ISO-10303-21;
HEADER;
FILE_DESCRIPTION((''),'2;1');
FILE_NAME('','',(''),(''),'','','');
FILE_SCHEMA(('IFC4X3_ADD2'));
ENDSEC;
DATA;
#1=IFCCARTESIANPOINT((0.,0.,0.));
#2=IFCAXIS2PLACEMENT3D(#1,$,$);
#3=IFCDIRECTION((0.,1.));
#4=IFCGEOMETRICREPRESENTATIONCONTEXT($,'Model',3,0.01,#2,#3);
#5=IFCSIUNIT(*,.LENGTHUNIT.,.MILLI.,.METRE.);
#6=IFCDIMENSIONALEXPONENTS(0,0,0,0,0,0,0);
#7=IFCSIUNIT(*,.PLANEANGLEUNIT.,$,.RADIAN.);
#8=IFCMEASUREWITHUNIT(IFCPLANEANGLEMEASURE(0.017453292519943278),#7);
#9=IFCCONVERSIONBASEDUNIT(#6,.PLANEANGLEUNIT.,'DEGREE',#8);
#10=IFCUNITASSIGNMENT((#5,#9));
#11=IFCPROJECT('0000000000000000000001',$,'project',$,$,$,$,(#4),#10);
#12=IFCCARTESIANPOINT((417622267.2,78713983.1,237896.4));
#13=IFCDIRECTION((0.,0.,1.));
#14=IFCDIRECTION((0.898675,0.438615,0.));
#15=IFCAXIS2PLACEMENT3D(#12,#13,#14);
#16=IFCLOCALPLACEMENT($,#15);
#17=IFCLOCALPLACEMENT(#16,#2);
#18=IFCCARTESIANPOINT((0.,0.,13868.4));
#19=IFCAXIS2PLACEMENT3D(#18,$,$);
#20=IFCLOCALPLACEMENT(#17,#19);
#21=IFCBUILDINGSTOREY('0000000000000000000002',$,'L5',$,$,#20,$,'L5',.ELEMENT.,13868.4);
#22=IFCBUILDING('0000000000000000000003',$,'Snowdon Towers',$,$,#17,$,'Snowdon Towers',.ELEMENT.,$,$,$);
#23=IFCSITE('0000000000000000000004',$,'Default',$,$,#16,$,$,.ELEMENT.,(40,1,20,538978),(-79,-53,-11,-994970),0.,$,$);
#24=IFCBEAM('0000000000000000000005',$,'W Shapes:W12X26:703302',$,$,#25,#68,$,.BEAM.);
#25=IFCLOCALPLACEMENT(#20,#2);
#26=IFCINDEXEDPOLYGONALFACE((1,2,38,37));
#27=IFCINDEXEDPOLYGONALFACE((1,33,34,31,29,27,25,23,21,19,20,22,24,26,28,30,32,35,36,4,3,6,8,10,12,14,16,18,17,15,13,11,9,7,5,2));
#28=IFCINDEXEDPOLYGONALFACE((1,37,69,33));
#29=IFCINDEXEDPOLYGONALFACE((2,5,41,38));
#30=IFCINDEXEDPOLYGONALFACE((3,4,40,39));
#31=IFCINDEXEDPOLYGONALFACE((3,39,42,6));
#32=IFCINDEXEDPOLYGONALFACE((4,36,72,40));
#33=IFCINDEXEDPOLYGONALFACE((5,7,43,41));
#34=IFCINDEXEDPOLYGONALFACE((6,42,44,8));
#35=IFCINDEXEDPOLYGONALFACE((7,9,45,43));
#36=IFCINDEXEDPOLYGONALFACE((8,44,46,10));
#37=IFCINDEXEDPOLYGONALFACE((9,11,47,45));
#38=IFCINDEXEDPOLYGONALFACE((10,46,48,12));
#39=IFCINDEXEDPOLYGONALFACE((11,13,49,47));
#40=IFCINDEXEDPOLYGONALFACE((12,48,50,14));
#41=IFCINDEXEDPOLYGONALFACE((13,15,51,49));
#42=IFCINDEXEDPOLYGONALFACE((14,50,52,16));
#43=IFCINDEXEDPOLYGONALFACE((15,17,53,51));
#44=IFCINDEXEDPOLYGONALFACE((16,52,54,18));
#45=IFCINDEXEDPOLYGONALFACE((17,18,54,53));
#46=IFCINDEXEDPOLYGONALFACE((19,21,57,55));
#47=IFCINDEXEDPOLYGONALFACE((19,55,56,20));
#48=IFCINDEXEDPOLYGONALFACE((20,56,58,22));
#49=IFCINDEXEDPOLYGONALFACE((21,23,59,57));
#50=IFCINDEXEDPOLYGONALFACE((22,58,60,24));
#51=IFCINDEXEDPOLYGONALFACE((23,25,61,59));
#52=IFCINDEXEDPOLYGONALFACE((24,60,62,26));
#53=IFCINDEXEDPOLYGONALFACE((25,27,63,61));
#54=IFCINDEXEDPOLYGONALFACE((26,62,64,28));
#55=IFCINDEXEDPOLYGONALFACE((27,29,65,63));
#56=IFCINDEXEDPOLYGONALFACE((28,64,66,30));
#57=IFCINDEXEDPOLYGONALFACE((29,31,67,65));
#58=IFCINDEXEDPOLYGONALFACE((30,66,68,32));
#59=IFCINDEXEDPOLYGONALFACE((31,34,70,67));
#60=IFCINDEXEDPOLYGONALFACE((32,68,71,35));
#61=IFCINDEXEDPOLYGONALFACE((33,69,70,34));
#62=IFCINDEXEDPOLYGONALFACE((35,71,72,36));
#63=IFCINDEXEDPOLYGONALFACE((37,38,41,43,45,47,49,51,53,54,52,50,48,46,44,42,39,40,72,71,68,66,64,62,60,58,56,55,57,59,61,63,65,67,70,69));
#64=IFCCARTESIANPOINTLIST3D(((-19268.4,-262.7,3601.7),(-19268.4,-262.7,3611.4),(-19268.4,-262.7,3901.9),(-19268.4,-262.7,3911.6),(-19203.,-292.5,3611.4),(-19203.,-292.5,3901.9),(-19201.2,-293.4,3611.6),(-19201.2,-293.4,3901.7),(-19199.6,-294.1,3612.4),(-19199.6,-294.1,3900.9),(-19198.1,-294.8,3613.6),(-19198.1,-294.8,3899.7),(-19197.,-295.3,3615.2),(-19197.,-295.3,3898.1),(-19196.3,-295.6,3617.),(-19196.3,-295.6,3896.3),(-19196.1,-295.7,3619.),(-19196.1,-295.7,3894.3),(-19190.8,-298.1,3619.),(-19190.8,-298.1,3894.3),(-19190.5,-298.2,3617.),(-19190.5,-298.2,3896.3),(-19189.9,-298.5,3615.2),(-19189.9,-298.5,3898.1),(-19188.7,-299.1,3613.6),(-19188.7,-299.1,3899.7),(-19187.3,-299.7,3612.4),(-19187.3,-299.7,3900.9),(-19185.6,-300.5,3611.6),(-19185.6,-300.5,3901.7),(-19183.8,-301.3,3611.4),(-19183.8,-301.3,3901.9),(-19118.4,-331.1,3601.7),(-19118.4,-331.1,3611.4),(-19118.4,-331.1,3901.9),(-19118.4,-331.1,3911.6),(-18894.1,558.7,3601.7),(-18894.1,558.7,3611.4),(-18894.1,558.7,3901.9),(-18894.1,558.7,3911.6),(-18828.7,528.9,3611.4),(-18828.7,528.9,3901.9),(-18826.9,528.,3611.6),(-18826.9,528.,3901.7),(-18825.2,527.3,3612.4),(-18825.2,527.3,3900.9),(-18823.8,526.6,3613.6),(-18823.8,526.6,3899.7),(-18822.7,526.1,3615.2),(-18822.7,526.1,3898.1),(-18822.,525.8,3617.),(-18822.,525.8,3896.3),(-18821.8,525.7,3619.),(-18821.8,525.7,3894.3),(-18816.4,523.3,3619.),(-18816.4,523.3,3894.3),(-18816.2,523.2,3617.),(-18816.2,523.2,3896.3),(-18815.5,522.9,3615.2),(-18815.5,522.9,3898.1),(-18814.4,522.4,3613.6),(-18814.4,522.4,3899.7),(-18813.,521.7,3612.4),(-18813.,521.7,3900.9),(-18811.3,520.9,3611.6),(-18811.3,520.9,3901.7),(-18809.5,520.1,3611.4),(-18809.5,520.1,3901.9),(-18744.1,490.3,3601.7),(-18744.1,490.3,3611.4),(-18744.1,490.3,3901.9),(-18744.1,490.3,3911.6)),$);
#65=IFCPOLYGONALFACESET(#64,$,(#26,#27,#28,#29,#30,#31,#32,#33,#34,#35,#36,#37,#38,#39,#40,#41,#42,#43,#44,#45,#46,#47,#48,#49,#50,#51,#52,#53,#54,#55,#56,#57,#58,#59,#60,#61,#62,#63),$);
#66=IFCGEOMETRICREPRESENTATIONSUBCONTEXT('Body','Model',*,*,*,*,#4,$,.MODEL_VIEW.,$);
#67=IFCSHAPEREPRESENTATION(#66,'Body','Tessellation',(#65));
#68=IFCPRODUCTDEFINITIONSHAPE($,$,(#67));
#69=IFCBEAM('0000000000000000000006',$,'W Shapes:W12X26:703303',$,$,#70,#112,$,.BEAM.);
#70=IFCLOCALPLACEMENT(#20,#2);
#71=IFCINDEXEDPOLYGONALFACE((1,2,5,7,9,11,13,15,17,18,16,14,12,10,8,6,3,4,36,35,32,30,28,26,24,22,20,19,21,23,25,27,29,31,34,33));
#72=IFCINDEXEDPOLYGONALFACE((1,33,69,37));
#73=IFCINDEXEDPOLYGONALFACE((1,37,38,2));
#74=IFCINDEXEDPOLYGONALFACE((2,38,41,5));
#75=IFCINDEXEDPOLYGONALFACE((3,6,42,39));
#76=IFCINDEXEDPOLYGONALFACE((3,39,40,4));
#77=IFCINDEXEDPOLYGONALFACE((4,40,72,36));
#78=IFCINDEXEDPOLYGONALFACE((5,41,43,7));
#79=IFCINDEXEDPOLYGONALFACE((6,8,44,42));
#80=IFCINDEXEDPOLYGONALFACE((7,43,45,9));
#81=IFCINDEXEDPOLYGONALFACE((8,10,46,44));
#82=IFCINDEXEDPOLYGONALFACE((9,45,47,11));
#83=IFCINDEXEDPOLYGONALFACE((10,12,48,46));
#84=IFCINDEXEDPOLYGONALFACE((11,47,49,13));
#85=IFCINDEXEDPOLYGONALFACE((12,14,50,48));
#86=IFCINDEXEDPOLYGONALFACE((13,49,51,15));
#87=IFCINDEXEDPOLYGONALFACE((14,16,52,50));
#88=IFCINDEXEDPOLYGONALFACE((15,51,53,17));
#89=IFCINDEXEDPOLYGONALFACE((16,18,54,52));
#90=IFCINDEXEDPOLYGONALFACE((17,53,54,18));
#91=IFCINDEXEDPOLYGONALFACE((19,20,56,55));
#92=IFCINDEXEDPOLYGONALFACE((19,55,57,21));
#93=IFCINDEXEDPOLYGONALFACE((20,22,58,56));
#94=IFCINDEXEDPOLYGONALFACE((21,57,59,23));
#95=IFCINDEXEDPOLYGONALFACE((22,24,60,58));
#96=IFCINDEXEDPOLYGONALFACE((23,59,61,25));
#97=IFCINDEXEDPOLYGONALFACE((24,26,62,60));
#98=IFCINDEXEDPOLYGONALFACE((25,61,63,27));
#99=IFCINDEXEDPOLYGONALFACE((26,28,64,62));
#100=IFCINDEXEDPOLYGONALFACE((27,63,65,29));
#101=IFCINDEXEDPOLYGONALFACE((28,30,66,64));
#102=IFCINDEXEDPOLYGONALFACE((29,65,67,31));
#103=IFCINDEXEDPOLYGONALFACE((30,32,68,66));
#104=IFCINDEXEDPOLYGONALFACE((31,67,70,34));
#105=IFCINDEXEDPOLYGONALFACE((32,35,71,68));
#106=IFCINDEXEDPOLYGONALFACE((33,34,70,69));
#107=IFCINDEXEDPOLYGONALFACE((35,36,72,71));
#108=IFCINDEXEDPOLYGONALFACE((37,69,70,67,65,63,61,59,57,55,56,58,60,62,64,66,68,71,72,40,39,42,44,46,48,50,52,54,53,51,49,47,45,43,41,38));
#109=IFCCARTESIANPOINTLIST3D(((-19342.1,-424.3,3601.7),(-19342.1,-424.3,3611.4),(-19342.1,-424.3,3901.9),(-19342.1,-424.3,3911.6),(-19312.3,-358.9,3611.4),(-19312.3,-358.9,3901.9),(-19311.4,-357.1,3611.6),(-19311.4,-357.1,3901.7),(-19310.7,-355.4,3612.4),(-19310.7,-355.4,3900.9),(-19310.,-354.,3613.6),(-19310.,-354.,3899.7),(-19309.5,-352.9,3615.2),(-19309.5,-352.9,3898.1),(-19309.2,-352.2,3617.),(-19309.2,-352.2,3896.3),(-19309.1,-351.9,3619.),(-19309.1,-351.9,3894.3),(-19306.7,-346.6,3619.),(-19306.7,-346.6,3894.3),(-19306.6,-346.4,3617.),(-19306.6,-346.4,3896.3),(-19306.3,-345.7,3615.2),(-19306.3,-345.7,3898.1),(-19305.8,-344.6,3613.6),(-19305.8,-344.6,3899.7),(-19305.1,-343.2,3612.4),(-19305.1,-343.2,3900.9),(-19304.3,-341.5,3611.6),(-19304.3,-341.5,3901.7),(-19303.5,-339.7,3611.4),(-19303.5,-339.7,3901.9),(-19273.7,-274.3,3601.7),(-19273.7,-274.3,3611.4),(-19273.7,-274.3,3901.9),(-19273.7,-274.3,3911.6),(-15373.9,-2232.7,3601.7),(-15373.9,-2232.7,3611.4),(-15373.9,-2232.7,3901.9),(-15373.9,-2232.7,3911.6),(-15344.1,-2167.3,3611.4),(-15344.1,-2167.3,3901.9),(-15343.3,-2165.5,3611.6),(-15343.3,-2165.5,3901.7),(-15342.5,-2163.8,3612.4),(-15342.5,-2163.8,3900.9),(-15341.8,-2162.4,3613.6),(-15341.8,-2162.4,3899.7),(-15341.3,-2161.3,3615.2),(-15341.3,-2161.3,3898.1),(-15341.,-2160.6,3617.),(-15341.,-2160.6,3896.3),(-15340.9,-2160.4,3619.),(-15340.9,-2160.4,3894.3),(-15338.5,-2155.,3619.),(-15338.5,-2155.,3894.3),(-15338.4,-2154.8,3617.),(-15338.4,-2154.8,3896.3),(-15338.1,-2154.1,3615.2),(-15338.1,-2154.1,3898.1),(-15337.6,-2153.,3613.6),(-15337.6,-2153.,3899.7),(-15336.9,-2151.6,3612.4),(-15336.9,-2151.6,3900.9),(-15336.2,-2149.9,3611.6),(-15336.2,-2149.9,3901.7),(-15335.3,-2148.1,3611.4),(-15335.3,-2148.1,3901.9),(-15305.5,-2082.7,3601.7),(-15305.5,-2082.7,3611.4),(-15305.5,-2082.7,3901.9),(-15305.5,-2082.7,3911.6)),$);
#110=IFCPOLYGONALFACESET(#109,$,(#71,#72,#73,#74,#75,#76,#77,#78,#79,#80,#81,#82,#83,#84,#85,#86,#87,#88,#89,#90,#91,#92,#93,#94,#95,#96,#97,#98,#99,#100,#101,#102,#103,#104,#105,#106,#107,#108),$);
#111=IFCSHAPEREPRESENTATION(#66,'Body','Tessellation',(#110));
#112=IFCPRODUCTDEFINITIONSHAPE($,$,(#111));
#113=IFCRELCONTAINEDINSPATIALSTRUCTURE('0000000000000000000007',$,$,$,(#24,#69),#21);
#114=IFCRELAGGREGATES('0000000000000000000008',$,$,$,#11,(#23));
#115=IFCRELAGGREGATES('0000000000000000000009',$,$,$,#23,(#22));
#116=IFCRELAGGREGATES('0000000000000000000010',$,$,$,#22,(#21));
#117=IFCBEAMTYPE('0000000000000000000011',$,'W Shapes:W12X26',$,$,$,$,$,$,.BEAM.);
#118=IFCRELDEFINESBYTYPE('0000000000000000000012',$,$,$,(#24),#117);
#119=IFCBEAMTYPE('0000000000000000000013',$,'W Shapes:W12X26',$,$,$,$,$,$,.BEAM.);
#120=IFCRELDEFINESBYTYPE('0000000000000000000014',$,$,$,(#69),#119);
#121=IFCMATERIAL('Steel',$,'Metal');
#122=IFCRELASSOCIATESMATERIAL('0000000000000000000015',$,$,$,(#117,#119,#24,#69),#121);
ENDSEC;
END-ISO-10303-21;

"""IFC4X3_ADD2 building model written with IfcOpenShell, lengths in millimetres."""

from ifc_helpers import new_model, entity, si_unit, converted_unit, direction, frame, frame_2d, origin, place, context, subcontext, project, spatial, polyline, circle_curve, parameter, trimmed, segment, composite_curve, outline, extrude, source, transform, mapped, material, material_profile, profile_set, profile_usage, type_object, type_shapes, element, save


model = new_model("IFC4X3_ADD2")

# Units and contexts
model_context = context("Model", 3, precision=0.01, world=origin(), true_north=direction((0.0, 1.0)))
body_context = subcontext(model_context, "Body", "Model", "MODEL_VIEW")
ifc_project = project(units=[si_unit("LENGTHUNIT", "METRE", prefix="MILLI"), converted_unit("PLANEANGLEUNIT", "DEGREE", entity("IfcPlaneAngleMeasure", 0.017453292519943278), si_unit("PLANEANGLEUNIT", "RADIAN"), dimensions=[0, 0, 0, 0, 0, 0, 0])], contexts=[model_context])

# Site, building, storey
site_placement = place(None, frame((417622267.2, 78713983.1, 237896.4), z_axis=(0.0, 0.0, 1.0), x_axis=(0.898675, 0.438615, 0.0)))
site = spatial("IfcSite", under=ifc_project, at=site_placement, Name="Default", CompositionType="ELEMENT", RefLatitude=(40, 1, 20, 538978), RefLongitude=(-79, -53, -11, -994970), RefElevation=0.0)
building_placement = place(site_placement, origin())
building = spatial("IfcBuilding", under=site, at=building_placement, Name="Snowdon Towers", LongName="Snowdon Towers", CompositionType="ELEMENT")
storey_placement = place(building_placement, frame((0.0, 0.0, 13868.4)))
storey = spatial("IfcBuildingStorey", under=building, at=storey_placement, Name="L5", LongName="L5", CompositionType="ELEMENT", Elevation=13868.4)

# Beams
ifc_material_1 = material(Name="Steel", Category="Metal")
ifc_material_profile_1 = material_profile(ifc_material_1, outline(composite_curve([segment(polyline([(-82.4, -145.3), (-82.4, -154.9)]), True, "CONTINUOUS"), segment(polyline([(-82.4, -154.9), (82.4, -154.9)]), True, "CONTINUOUS"), segment(polyline([(82.4, -154.9), (82.4, -145.3)]), True, "CONTINUOUS"), segment(polyline([(82.4, -145.3), (10.5, -145.3)]), True, "CONTINUOUS"), segment(trimmed(circle_curve(frame_2d((10.5, -137.7), x_axis=(1.0, 0.0)), 7.6), [parameter(180.0)], [parameter(270.0)], True, "PARAMETER"), False, "CONTINUOUS"), segment(polyline([(2.9, -137.7), (2.9, 137.7)]), True, "CONTINUOUS"), segment(trimmed(circle_curve(frame_2d((10.5, 137.7), x_axis=(1.0, 0.0)), 7.6), [parameter(90.0)], [parameter(180.0)], True, "PARAMETER"), False, "CONTINUOUS"), segment(polyline([(10.5, 145.3), (82.4, 145.3)]), True, "CONTINUOUS"), segment(polyline([(82.4, 145.3), (82.4, 154.9)]), True, "CONTINUOUS"), segment(polyline([(82.4, 154.9), (-82.4, 154.9)]), True, "CONTINUOUS"), segment(polyline([(-82.4, 154.9), (-82.4, 145.3)]), True, "CONTINUOUS"), segment(polyline([(-82.4, 145.3), (-10.5, 145.3)]), True, "CONTINUOUS"), segment(trimmed(circle_curve(frame_2d((-10.5, 137.7), x_axis=(1.0, 0.0)), 7.6), [parameter(360.0)], [parameter(90.0)], True, "PARAMETER"), False, "CONTINUOUS"), segment(polyline([(-2.9, 137.7), (-2.9, -137.7)]), True, "CONTINUOUS"), segment(trimmed(circle_curve(frame_2d((-10.5, -137.7), x_axis=(1.0, 0.0)), 7.6), [parameter(270.0)], [parameter(360.0)], True, "PARAMETER"), False, "CONTINUOUS"), segment(polyline([(-10.5, -145.3), (-82.4, -145.3)]), True, "CONTINUOUS")], self_intersect=False)), Name="W12X26")
ifc_profile_set_1 = profile_set([ifc_material_profile_1], Name="W12X26")
ifc_profile_usage_1 = profile_usage(ifc_profile_set_1, cardinal=8)
beam_type_1 = type_object("IfcBeamType", Name="W Shapes:W12X26", PredefinedType="BEAM", material=ifc_profile_set_1)
shared_shape_1 = source(origin(), body_context, "Body", "SweptSolid", [
    extrude(outline(composite_curve([segment(polyline([(-82.4, -145.3), (-82.4, -154.9)]), True, "CONTINUOUS"), segment(polyline([(-82.4, -154.9), (82.4, -154.9)]), True, "CONTINUOUS"), segment(polyline([(82.4, -154.9), (82.4, -145.3)]), True, "CONTINUOUS"), segment(polyline([(82.4, -145.3), (10.5, -145.3)]), True, "CONTINUOUS"), segment(trimmed(circle_curve(frame_2d((10.5, -137.7), x_axis=(0.0, -1.0)), 7.6), [parameter(270.0)], [parameter(360.0)], True, "PARAMETER"), False, "CONTINUOUS"), segment(polyline([(2.9, -137.7), (2.9, 137.7)]), True, "CONTINUOUS"), segment(trimmed(circle_curve(frame_2d((10.5, 137.7), x_axis=(-1.0, 0.0)), 7.6), [parameter(270.0)], [parameter(360.0)], True, "PARAMETER"), False, "CONTINUOUS"), segment(polyline([(10.5, 145.3), (82.4, 145.3)]), True, "CONTINUOUS"), segment(polyline([(82.4, 145.3), (82.4, 154.9)]), True, "CONTINUOUS"), segment(polyline([(82.4, 154.9), (-82.4, 154.9)]), True, "CONTINUOUS"), segment(polyline([(-82.4, 154.9), (-82.4, 145.3)]), True, "CONTINUOUS"), segment(polyline([(-82.4, 145.3), (-10.5, 145.3)]), True, "CONTINUOUS"), segment(trimmed(circle_curve(frame_2d((-10.5, 137.7), x_axis=(0.0, 1.0)), 7.6), [parameter(270.0)], [parameter(0.0)], True, "PARAMETER"), False, "CONTINUOUS"), segment(polyline([(-2.9, 137.7), (-2.9, -137.7)]), True, "CONTINUOUS"), segment(trimmed(circle_curve(frame_2d((-10.5, -137.7), x_axis=(1.0, 0.0)), 7.6), [parameter(270.0)], [parameter(0.0)], True, "PARAMETER"), False, "CONTINUOUS"), segment(polyline([(-10.5, -145.3), (-82.4, -145.3)]), True, "CONTINUOUS")], self_intersect=False)), frame((-534.3, 0.0, 0.0), z_axis=(-1.0, 0.0, 0.0), x_axis=(0.0, -1.0, 0.0)), (0.0, 0.0, -1.0), 902.7),
])
type_shapes(beam_type_1, [shared_shape_1])
beam_1_placement = place(storey_placement, frame((-18971.9, 189.3, 3756.7), z_axis=(0.0, 0.0, 1.0), x_axis=(0.414693, 0.909961, 0.0)))
element("IfcBeam", 1, at=beam_1_placement, inside=storey, type_object=beam_type_1, material=ifc_profile_usage_1, Name="W Shapes:W12X26:703302", PredefinedType="BEAM", context=body_context, shape_type="MappedRepresentation", body=[
    mapped(shared_shape_1, transform((0.0, 0.0, 0.0), scale=1.0)),
])
beam_type_2 = type_object("IfcBeamType", Name="W Shapes:W12X26", PredefinedType="BEAM", material=ifc_profile_set_1)
shared_shape_2 = source(origin(), body_context, "Body", "SweptSolid", [
    extrude(outline(composite_curve([segment(polyline([(-82.4, -145.3), (-82.4, -154.9)]), True, "CONTINUOUS"), segment(polyline([(-82.4, -154.9), (82.4, -154.9)]), True, "CONTINUOUS"), segment(polyline([(82.4, -154.9), (82.4, -145.3)]), True, "CONTINUOUS"), segment(polyline([(82.4, -145.3), (10.5, -145.3)]), True, "CONTINUOUS"), segment(trimmed(circle_curve(frame_2d((10.5, -137.7), x_axis=(1.0, 0.0)), 7.6), [parameter(180.0)], [parameter(270.0)], True, "PARAMETER"), False, "CONTINUOUS"), segment(polyline([(2.9, -137.7), (2.9, 137.7)]), True, "CONTINUOUS"), segment(trimmed(circle_curve(frame_2d((10.5, 137.7), x_axis=(1.0, 0.0)), 7.6), [parameter(90.0)], [parameter(180.0)], True, "PARAMETER"), False, "CONTINUOUS"), segment(polyline([(10.5, 145.3), (82.4, 145.3)]), True, "CONTINUOUS"), segment(polyline([(82.4, 145.3), (82.4, 154.9)]), True, "CONTINUOUS"), segment(polyline([(82.4, 154.9), (-82.4, 154.9)]), True, "CONTINUOUS"), segment(polyline([(-82.4, 154.9), (-82.4, 145.3)]), True, "CONTINUOUS"), segment(polyline([(-82.4, 145.3), (-10.5, 145.3)]), True, "CONTINUOUS"), segment(trimmed(circle_curve(frame_2d((-10.5, 137.7), x_axis=(1.0, 0.0)), 7.6), [parameter(360.0)], [parameter(90.0)], True, "PARAMETER"), False, "CONTINUOUS"), segment(polyline([(-2.9, 137.7), (-2.9, -137.7)]), True, "CONTINUOUS"), segment(trimmed(circle_curve(frame_2d((-10.5, -137.7), x_axis=(1.0, 0.0)), 7.6), [parameter(270.0)], [parameter(360.0)], True, "PARAMETER"), False, "CONTINUOUS"), segment(polyline([(-10.5, -145.3), (-82.4, -145.3)]), True, "CONTINUOUS")], self_intersect=False)), frame((-2280.3, 0.0, 0.0), z_axis=(-1.0, 0.0, 0.0), x_axis=(0.0, -1.0, 0.0)), (0.0, 0.0, -1.0), 4360.8),
])
type_shapes(beam_type_2, [shared_shape_2])
beam_2_placement = place(storey_placement, frame((-17232.9, -1294.9, 3756.7), z_axis=(0.0, 0.0, 1.0), x_axis=(0.909961, -0.414693, 0.0)))
element("IfcBeam", 2, at=beam_2_placement, inside=storey, type_object=beam_type_2, material=ifc_profile_usage_1, Name="W Shapes:W12X26:703303", PredefinedType="BEAM", context=body_context, shape_type="MappedRepresentation", body=[
    mapped(shared_shape_2, transform((0.0, 0.0, 0.0), scale=1.0)),
])

save(model, "model.ifc")
